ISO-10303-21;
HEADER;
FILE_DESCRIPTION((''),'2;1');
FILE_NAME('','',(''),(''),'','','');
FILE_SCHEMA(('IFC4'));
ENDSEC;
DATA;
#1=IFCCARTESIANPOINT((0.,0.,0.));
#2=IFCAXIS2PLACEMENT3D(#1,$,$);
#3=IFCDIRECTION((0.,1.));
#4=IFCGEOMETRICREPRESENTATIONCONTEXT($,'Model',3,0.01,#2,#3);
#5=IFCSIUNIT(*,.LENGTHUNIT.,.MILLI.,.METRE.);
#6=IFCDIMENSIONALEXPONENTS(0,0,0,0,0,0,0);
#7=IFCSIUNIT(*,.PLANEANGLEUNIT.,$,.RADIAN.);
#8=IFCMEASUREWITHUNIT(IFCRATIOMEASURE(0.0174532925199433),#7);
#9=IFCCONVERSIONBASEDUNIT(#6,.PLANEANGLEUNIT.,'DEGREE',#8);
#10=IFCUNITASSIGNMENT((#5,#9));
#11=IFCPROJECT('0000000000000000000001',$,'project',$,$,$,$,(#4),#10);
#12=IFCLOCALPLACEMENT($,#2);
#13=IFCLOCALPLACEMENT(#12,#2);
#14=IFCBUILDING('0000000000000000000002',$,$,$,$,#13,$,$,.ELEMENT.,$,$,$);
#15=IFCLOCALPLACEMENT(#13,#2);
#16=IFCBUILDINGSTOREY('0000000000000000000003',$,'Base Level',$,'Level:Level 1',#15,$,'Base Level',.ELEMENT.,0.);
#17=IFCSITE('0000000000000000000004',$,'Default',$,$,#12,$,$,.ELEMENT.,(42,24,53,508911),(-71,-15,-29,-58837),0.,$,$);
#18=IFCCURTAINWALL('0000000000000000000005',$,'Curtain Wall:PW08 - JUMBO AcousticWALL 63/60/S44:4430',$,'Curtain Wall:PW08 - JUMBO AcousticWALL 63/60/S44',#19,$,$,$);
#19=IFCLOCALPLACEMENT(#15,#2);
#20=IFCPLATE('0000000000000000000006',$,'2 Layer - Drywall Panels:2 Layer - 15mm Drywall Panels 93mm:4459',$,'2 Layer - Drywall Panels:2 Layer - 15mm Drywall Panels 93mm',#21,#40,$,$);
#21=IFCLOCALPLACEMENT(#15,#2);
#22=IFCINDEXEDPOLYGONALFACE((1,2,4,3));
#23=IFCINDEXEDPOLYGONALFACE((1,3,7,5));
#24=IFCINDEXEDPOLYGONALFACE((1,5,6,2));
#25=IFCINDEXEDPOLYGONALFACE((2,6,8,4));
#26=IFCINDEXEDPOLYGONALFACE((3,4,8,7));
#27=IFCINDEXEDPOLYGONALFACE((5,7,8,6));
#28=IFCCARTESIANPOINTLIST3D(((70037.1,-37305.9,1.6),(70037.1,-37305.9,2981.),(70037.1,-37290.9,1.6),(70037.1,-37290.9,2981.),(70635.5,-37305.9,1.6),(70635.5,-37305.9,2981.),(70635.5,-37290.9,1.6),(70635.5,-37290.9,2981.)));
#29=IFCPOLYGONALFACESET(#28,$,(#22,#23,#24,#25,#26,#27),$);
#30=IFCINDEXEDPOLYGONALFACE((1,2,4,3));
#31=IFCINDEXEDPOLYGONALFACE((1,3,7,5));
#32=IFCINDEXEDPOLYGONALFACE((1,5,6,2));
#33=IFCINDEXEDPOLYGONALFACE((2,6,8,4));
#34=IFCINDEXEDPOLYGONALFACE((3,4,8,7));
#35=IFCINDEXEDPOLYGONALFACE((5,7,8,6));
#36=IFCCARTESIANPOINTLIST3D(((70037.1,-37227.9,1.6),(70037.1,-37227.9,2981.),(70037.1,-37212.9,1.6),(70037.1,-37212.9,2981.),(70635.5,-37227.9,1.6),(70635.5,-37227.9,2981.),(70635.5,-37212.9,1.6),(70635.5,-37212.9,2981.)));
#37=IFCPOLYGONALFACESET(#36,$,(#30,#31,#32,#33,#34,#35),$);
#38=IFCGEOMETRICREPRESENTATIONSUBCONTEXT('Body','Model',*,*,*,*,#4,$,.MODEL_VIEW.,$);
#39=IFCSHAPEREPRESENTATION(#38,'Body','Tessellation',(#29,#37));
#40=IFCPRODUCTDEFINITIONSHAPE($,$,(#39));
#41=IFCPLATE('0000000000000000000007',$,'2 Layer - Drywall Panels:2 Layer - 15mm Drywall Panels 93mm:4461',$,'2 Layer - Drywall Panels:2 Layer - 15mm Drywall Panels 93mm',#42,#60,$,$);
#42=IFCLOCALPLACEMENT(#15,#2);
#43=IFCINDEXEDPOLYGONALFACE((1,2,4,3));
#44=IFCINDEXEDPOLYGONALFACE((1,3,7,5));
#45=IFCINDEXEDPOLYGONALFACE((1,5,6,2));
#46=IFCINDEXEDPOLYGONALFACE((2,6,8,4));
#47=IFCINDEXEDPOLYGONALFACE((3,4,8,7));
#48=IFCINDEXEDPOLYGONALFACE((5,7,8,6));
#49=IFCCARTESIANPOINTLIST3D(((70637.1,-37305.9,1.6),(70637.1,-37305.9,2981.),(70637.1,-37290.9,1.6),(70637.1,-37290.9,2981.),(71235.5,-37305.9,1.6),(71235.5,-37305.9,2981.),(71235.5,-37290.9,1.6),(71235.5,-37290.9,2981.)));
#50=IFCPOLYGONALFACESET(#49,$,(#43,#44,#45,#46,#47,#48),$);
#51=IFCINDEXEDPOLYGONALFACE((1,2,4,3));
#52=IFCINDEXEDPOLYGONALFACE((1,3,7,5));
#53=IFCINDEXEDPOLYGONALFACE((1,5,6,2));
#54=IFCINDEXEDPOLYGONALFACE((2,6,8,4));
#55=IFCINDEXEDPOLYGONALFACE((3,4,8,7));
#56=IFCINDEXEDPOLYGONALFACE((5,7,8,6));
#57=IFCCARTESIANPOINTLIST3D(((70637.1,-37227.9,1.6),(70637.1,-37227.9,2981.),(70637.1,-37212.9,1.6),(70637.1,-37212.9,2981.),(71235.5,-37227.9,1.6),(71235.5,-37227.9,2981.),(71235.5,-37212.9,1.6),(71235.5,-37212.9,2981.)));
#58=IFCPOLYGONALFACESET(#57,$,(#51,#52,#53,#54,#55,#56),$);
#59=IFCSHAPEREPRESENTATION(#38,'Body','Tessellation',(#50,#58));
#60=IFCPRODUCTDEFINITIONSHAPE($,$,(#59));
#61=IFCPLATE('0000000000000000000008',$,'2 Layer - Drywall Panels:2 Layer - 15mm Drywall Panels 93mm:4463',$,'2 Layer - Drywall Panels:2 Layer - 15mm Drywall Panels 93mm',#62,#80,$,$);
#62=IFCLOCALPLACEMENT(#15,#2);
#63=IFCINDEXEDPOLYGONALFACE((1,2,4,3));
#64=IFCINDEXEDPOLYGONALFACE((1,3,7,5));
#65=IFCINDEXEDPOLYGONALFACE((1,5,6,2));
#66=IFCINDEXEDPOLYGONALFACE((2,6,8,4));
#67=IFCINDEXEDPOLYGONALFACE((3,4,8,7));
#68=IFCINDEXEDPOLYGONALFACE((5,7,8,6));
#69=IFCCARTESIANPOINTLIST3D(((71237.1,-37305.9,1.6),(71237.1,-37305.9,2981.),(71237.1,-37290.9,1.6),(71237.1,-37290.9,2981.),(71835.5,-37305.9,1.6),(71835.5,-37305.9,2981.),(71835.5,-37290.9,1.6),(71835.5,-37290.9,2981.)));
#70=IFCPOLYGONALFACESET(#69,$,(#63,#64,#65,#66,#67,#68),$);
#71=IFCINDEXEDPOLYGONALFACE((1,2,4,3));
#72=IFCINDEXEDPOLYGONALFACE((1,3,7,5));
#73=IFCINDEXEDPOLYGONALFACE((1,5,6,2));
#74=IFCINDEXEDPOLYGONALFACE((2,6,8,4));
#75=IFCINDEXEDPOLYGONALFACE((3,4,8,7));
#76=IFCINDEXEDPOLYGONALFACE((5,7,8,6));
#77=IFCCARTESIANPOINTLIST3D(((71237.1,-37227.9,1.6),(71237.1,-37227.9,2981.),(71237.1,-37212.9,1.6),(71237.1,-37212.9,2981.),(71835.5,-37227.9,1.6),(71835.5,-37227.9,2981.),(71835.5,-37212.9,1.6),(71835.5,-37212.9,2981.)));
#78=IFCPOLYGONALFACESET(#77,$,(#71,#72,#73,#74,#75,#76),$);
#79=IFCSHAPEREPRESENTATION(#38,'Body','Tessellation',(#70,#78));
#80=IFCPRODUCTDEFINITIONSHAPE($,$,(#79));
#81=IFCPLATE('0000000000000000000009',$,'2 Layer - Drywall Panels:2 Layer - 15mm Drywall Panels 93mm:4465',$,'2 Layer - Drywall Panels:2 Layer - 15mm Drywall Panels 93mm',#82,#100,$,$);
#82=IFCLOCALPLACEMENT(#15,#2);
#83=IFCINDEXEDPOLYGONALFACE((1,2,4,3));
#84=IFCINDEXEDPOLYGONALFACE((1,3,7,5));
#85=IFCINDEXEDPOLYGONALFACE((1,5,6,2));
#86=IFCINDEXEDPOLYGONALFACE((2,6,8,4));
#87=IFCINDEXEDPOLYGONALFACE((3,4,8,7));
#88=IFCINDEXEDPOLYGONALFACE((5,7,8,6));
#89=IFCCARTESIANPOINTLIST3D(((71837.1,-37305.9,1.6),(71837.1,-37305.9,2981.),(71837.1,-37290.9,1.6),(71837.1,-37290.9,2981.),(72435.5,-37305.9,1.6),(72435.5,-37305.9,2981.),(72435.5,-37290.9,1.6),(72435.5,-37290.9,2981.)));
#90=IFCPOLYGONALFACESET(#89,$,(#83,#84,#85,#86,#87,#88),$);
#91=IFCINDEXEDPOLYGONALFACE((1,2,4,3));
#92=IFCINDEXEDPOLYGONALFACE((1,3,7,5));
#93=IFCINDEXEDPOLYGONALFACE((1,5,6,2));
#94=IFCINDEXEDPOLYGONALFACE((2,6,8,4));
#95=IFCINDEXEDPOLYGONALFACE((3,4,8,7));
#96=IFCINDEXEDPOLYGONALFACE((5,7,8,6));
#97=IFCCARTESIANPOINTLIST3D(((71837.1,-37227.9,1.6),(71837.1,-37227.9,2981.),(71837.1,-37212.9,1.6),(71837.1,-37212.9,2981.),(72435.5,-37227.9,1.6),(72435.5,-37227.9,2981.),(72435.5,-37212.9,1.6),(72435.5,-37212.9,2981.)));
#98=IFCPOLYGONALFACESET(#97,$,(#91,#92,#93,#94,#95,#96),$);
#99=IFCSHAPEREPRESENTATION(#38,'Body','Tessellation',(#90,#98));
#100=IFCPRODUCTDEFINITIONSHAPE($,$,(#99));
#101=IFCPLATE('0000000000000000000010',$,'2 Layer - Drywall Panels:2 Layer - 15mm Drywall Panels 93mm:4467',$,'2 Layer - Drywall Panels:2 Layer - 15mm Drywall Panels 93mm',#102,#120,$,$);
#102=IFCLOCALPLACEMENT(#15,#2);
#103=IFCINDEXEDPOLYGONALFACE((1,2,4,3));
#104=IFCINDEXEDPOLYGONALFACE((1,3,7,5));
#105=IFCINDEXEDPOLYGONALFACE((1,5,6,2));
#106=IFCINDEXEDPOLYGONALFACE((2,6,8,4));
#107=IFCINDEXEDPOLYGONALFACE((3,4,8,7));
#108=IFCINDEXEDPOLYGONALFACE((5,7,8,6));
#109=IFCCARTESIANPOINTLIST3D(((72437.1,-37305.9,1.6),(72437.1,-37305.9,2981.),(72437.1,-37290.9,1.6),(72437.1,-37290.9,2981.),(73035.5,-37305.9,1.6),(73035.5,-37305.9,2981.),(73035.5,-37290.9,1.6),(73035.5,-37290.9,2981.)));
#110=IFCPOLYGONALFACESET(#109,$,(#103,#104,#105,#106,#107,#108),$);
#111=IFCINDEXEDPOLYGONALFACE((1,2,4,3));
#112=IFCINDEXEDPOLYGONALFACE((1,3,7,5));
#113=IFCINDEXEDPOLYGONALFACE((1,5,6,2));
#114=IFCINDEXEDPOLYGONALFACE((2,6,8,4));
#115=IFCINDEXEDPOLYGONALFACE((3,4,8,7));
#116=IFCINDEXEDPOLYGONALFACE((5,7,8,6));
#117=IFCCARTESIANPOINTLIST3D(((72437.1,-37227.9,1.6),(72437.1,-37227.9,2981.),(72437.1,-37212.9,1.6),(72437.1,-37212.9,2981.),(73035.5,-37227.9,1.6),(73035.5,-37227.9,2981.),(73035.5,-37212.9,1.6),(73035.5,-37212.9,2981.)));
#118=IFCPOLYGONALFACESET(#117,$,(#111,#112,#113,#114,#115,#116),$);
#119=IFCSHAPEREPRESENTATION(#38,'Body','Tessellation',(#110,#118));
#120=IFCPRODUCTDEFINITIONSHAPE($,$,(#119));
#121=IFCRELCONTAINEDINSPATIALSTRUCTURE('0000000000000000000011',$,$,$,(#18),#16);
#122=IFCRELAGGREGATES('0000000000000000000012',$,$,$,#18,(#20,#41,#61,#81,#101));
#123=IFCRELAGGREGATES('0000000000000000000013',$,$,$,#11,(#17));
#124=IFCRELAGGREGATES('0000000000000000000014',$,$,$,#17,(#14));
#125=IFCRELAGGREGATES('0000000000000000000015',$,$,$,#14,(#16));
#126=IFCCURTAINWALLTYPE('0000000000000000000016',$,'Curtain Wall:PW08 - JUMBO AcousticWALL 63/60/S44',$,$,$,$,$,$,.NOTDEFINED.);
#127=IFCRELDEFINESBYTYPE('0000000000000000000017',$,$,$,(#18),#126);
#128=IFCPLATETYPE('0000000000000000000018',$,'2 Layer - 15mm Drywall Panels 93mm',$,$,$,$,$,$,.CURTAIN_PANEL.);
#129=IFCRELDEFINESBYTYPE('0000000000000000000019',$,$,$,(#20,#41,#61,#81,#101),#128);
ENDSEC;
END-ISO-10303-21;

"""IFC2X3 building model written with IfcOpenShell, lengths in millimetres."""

from ifc_helpers import new_model, entity, si_unit, converted_unit, direction, frame, frame_2d, origin, place, context, subcontext, project, spatial, rectangle, extrude, source, transform, mapped, type_object, type_shapes, element, aggregate, save


model = new_model("IFC2X3")

# Units and contexts
model_context = context("Model", 3, precision=0.01, world=origin(), true_north=direction((0.0, 1.0)))
body_context = subcontext(model_context, "Body", "Model", "MODEL_VIEW")
ifc_project = project(units=[si_unit("LENGTHUNIT", "METRE", prefix="MILLI"), converted_unit("PLANEANGLEUNIT", "DEGREE", entity("IfcRatioMeasure", 0.0174532925199433), si_unit("PLANEANGLEUNIT", "RADIAN"), dimensions=[0, 0, 0, 0, 0, 0, 0])], contexts=[model_context])

# Site, building, storey
site_placement = place(None, origin())
site = spatial("IfcSite", under=ifc_project, at=site_placement, Name="Default", CompositionType="ELEMENT", RefLatitude=(42, 24, 53, 508911), RefLongitude=(-71, -15, -29, -58837), RefElevation=0.0)
building_placement = place(site_placement, origin())
building = spatial("IfcBuilding", under=site, at=building_placement, CompositionType="ELEMENT")
storey_placement = place(building_placement, origin())
storey = spatial("IfcBuildingStorey", under=building, at=storey_placement, Name="Base Level", ObjectType="Level:Level 1", LongName="Base Level", CompositionType="ELEMENT", Elevation=0.0)

# Curtain wall, plates
curtain_wall_type = type_object("IfcCurtainWallType", Name="Curtain Wall:PW08 - JUMBO AcousticWALL 63/60/S44", PredefinedType="NOTDEFINED")
curtain_wall_placement = place(building_placement, origin())
curtain_wall = element("IfcCurtainWall", 1, at=curtain_wall_placement, inside=storey, type_object=curtain_wall_type, Name="Curtain Wall:PW08 - JUMBO AcousticWALL 63/60/S44:4430", ObjectType="Curtain Wall:PW08 - JUMBO AcousticWALL 63/60/S44")
plate_type = type_object("IfcPlateType", Name="2 Layer - 15mm Drywall Panels 93mm", PredefinedType="CURTAIN_PANEL")
shared_shape_1 = source(origin(), body_context, "Body", "SweptSolid", [
    extrude(rectangle(XDim=598.4, YDim=15.0, at=frame_2d((0.0, 0.0), x_axis=(1.0, 0.0))), frame((0.0, -39.0, 0.0), z_axis=(0.0, 0.0, 1.0), x_axis=(-1.0, 0.0, 0.0)), (0.0, 0.0, 1.0), 2979.4),
    extrude(rectangle(XDim=15.0, YDim=598.4, at=frame_2d((0.0, 0.0), x_axis=(1.0, 0.0))), frame((0.0, 39.0, 0.0), z_axis=(0.0, 0.0, 1.0), x_axis=(0.0, 1.0, 0.0)), (0.0, 0.0, 1.0), 2979.4),
])
type_shapes(plate_type, [shared_shape_1])
plate_1_placement = place(curtain_wall_placement, frame((70336.3, -37259.4, 1.6)))
plate_1 = element("IfcPlate", 2, at=plate_1_placement, type_object=plate_type, Name="2 Layer - Drywall Panels:2 Layer - 15mm Drywall Panels 93mm:4459", ObjectType="2 Layer - Drywall Panels:2 Layer - 15mm Drywall Panels 93mm", context=body_context, shape_type="MappedRepresentation", body=[
    mapped(shared_shape_1, transform((0.0, 0.0, 0.0), scale=1.0)),
])
plate_2_placement = place(curtain_wall_placement, frame((70936.3, -37259.4, 1.6)))
plate_2 = element("IfcPlate", 3, at=plate_2_placement, type_object=plate_type, Name="2 Layer - Drywall Panels:2 Layer - 15mm Drywall Panels 93mm:4461", ObjectType="2 Layer - Drywall Panels:2 Layer - 15mm Drywall Panels 93mm", context=body_context, shape_type="MappedRepresentation", body=[
    mapped(shared_shape_1, transform((0.0, 0.0, 0.0), scale=1.0)),
])
plate_3_placement = place(curtain_wall_placement, frame((71536.3, -37259.4, 1.6)))
plate_3 = element("IfcPlate", 4, at=plate_3_placement, type_object=plate_type, Name="2 Layer - Drywall Panels:2 Layer - 15mm Drywall Panels 93mm:4463", ObjectType="2 Layer - Drywall Panels:2 Layer - 15mm Drywall Panels 93mm", context=body_context, shape_type="MappedRepresentation", body=[
    mapped(shared_shape_1, transform((0.0, 0.0, 0.0), scale=1.0)),
])
plate_4_placement = place(curtain_wall_placement, frame((72136.3, -37259.4, 1.6)))
plate_4 = element("IfcPlate", 5, at=plate_4_placement, type_object=plate_type, Name="2 Layer - Drywall Panels:2 Layer - 15mm Drywall Panels 93mm:4465", ObjectType="2 Layer - Drywall Panels:2 Layer - 15mm Drywall Panels 93mm", context=body_context, shape_type="MappedRepresentation", body=[
    mapped(shared_shape_1, transform((0.0, 0.0, 0.0), scale=1.0)),
])
plate_5_placement = place(curtain_wall_placement, frame((72736.3, -37259.4, 1.6)))
plate_5 = element("IfcPlate", 6, at=plate_5_placement, type_object=plate_type, Name="2 Layer - Drywall Panels:2 Layer - 15mm Drywall Panels 93mm:4467", ObjectType="2 Layer - Drywall Panels:2 Layer - 15mm Drywall Panels 93mm", context=body_context, shape_type="MappedRepresentation", body=[
    mapped(shared_shape_1, transform((0.0, 0.0, 0.0), scale=1.0)),
])
aggregate(curtain_wall, [plate_1, plate_2, plate_3, plate_4, plate_5])

save(model, "model.ifc")
